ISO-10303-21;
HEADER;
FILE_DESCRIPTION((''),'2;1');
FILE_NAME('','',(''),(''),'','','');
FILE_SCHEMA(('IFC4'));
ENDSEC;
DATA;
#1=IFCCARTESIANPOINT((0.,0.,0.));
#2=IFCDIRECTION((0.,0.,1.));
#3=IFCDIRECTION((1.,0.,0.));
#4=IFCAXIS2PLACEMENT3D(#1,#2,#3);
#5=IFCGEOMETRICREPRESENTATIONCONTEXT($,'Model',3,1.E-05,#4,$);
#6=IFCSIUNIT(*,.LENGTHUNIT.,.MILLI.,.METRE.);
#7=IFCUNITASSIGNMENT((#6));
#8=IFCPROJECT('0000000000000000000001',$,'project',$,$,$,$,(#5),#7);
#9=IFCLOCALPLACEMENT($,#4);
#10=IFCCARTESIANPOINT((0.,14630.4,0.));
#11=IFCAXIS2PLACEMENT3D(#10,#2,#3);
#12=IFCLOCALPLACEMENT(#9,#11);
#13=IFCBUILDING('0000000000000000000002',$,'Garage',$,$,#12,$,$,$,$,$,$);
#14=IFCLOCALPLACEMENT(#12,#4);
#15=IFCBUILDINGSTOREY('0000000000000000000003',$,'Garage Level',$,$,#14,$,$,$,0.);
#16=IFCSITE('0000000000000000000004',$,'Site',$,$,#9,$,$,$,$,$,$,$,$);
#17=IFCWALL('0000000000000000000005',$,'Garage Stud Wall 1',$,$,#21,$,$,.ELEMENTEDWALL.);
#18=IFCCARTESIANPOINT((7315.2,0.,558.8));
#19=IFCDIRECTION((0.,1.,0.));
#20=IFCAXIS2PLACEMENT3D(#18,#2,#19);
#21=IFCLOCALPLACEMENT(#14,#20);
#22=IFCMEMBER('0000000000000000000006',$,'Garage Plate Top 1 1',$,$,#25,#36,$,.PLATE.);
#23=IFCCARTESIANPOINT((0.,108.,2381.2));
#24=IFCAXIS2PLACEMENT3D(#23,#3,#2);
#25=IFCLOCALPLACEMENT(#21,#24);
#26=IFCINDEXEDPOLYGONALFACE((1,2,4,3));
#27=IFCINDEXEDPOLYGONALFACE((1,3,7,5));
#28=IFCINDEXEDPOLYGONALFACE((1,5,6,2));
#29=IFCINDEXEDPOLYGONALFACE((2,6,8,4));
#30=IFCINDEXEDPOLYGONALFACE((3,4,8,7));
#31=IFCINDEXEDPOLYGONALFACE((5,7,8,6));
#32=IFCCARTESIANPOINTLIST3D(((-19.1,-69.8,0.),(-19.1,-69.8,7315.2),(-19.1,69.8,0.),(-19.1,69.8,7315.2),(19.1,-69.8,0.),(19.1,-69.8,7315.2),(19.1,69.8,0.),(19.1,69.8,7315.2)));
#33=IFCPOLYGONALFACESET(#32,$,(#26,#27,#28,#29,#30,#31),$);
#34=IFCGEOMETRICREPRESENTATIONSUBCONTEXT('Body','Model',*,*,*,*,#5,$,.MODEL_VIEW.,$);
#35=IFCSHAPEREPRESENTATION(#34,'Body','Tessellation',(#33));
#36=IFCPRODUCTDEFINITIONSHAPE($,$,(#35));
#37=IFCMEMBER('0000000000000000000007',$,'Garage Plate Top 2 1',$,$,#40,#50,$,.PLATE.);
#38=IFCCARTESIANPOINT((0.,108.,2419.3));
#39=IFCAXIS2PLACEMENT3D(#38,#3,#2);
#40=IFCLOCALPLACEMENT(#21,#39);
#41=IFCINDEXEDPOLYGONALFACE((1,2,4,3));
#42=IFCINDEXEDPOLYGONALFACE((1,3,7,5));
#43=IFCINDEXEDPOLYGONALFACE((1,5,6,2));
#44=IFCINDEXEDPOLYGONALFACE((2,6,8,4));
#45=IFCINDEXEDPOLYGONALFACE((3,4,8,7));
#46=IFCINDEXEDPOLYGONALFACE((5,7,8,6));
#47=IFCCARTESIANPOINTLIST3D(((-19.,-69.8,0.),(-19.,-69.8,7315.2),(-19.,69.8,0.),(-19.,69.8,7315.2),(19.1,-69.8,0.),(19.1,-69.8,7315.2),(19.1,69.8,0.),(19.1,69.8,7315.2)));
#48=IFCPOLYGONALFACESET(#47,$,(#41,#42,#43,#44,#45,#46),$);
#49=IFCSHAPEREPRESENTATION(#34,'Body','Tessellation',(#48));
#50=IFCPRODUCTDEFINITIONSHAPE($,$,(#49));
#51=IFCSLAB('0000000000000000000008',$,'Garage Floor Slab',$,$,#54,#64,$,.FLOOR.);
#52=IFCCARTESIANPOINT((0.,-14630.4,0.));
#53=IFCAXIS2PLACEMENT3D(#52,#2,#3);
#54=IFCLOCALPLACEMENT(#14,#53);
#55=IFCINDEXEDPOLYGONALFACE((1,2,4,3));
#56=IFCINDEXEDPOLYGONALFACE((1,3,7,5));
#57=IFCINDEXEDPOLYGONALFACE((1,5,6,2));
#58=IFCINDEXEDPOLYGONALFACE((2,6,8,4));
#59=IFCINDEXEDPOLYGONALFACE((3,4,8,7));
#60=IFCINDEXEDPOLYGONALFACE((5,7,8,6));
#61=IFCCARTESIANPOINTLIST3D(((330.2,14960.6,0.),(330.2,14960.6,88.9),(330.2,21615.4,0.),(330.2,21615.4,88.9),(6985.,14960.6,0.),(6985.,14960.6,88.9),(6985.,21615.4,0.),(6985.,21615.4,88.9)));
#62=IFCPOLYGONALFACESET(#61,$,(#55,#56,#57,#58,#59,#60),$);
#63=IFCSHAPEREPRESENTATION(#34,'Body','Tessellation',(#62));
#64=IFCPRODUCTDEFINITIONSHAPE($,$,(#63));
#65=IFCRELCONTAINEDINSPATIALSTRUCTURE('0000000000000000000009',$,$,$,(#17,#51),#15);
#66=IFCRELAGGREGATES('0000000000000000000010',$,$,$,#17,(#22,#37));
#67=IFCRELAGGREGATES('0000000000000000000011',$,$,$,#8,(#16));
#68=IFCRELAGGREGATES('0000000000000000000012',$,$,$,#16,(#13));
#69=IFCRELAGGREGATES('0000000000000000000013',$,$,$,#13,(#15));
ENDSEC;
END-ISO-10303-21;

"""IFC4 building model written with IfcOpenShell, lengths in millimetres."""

from ifc_helpers import new_model, si_unit, frame, origin_with_axes, origin_2d, place, context, subcontext, project, spatial, indexed_curve, rectangle, outline, extrude, element, aggregate, save


model = new_model("IFC4")

# Units and contexts
model_context = context("Model", 3, precision=1e-05, world=origin_with_axes())
body_context = subcontext(model_context, "Body", "Model", "MODEL_VIEW")
ifc_project = project(units=[si_unit("LENGTHUNIT", "METRE", prefix="MILLI")], contexts=[model_context])

# Site, building, storey
site_placement = place(None, origin_with_axes())
site = spatial("IfcSite", under=ifc_project, at=site_placement, Name="Site")
building_placement = place(site_placement, frame((0.0, 14630.4, 0.0), z_axis=(0.0, 0.0, 1.0), x_axis=(1.0, 0.0, 0.0)))
building = spatial("IfcBuilding", under=site, at=building_placement, Name="Garage")
storey_placement = place(building_placement, origin_with_axes())
storey = spatial("IfcBuildingStorey", under=building, at=storey_placement, Name="Garage Level", Elevation=0.0)

# Wall, members
wall_1_placement = place(storey_placement, frame((7315.2, 0.0, 558.8), z_axis=(0.0, 0.0, 1.0), x_axis=(0.0, 1.0, 0.0)))
wall_1 = element("IfcWall", 1, at=wall_1_placement, inside=storey, Name="Garage Stud Wall 1", PredefinedType="ELEMENTEDWALL")
member_1_placement = place(wall_1_placement, frame((0.0, 108.0, 2381.2), z_axis=(1.0, 0.0, 0.0), x_axis=(0.0, 0.0, 1.0)))
member_1 = element("IfcMember", 2, at=member_1_placement, Name="Garage Plate Top 1 1", PredefinedType="PLATE", context=body_context, shape_type="SweptSolid", body=[
    extrude(rectangle(XDim=38.1, YDim=139.7, at=origin_2d()), origin_with_axes(), (0.0, 0.0, 1.0), 7315.2),
])
member_2_placement = place(wall_1_placement, frame((0.0, 108.0, 2419.3), z_axis=(1.0, 0.0, 0.0), x_axis=(0.0, 0.0, 1.0)))
member_2 = element("IfcMember", 3, at=member_2_placement, Name="Garage Plate Top 2 1", PredefinedType="PLATE", context=body_context, shape_type="SweptSolid", body=[
    extrude(rectangle(XDim=38.1, YDim=139.7, at=origin_2d()), origin_with_axes(), (0.0, 0.0, 1.0), 7315.2),
])
aggregate(wall_1, [member_1, member_2])

# Slab
slab_placement = place(storey_placement, frame((0.0, -14630.4, 0.0), z_axis=(0.0, 0.0, 1.0), x_axis=(1.0, 0.0, 0.0)))
element("IfcSlab", 4, at=slab_placement, inside=storey, Name="Garage Floor Slab", PredefinedType="FLOOR", context=body_context, shape_type="SweptSolid", body=[
    extrude(outline(indexed_curve([(6985.0, 14960.6), (6985.0, 21615.4), (330.2, 21615.4), (330.2, 14960.6), (6985.0, 14960.6)])), None, (0.0, 0.0, 1.0), 88.9),
])

save(model, "model.ifc")
